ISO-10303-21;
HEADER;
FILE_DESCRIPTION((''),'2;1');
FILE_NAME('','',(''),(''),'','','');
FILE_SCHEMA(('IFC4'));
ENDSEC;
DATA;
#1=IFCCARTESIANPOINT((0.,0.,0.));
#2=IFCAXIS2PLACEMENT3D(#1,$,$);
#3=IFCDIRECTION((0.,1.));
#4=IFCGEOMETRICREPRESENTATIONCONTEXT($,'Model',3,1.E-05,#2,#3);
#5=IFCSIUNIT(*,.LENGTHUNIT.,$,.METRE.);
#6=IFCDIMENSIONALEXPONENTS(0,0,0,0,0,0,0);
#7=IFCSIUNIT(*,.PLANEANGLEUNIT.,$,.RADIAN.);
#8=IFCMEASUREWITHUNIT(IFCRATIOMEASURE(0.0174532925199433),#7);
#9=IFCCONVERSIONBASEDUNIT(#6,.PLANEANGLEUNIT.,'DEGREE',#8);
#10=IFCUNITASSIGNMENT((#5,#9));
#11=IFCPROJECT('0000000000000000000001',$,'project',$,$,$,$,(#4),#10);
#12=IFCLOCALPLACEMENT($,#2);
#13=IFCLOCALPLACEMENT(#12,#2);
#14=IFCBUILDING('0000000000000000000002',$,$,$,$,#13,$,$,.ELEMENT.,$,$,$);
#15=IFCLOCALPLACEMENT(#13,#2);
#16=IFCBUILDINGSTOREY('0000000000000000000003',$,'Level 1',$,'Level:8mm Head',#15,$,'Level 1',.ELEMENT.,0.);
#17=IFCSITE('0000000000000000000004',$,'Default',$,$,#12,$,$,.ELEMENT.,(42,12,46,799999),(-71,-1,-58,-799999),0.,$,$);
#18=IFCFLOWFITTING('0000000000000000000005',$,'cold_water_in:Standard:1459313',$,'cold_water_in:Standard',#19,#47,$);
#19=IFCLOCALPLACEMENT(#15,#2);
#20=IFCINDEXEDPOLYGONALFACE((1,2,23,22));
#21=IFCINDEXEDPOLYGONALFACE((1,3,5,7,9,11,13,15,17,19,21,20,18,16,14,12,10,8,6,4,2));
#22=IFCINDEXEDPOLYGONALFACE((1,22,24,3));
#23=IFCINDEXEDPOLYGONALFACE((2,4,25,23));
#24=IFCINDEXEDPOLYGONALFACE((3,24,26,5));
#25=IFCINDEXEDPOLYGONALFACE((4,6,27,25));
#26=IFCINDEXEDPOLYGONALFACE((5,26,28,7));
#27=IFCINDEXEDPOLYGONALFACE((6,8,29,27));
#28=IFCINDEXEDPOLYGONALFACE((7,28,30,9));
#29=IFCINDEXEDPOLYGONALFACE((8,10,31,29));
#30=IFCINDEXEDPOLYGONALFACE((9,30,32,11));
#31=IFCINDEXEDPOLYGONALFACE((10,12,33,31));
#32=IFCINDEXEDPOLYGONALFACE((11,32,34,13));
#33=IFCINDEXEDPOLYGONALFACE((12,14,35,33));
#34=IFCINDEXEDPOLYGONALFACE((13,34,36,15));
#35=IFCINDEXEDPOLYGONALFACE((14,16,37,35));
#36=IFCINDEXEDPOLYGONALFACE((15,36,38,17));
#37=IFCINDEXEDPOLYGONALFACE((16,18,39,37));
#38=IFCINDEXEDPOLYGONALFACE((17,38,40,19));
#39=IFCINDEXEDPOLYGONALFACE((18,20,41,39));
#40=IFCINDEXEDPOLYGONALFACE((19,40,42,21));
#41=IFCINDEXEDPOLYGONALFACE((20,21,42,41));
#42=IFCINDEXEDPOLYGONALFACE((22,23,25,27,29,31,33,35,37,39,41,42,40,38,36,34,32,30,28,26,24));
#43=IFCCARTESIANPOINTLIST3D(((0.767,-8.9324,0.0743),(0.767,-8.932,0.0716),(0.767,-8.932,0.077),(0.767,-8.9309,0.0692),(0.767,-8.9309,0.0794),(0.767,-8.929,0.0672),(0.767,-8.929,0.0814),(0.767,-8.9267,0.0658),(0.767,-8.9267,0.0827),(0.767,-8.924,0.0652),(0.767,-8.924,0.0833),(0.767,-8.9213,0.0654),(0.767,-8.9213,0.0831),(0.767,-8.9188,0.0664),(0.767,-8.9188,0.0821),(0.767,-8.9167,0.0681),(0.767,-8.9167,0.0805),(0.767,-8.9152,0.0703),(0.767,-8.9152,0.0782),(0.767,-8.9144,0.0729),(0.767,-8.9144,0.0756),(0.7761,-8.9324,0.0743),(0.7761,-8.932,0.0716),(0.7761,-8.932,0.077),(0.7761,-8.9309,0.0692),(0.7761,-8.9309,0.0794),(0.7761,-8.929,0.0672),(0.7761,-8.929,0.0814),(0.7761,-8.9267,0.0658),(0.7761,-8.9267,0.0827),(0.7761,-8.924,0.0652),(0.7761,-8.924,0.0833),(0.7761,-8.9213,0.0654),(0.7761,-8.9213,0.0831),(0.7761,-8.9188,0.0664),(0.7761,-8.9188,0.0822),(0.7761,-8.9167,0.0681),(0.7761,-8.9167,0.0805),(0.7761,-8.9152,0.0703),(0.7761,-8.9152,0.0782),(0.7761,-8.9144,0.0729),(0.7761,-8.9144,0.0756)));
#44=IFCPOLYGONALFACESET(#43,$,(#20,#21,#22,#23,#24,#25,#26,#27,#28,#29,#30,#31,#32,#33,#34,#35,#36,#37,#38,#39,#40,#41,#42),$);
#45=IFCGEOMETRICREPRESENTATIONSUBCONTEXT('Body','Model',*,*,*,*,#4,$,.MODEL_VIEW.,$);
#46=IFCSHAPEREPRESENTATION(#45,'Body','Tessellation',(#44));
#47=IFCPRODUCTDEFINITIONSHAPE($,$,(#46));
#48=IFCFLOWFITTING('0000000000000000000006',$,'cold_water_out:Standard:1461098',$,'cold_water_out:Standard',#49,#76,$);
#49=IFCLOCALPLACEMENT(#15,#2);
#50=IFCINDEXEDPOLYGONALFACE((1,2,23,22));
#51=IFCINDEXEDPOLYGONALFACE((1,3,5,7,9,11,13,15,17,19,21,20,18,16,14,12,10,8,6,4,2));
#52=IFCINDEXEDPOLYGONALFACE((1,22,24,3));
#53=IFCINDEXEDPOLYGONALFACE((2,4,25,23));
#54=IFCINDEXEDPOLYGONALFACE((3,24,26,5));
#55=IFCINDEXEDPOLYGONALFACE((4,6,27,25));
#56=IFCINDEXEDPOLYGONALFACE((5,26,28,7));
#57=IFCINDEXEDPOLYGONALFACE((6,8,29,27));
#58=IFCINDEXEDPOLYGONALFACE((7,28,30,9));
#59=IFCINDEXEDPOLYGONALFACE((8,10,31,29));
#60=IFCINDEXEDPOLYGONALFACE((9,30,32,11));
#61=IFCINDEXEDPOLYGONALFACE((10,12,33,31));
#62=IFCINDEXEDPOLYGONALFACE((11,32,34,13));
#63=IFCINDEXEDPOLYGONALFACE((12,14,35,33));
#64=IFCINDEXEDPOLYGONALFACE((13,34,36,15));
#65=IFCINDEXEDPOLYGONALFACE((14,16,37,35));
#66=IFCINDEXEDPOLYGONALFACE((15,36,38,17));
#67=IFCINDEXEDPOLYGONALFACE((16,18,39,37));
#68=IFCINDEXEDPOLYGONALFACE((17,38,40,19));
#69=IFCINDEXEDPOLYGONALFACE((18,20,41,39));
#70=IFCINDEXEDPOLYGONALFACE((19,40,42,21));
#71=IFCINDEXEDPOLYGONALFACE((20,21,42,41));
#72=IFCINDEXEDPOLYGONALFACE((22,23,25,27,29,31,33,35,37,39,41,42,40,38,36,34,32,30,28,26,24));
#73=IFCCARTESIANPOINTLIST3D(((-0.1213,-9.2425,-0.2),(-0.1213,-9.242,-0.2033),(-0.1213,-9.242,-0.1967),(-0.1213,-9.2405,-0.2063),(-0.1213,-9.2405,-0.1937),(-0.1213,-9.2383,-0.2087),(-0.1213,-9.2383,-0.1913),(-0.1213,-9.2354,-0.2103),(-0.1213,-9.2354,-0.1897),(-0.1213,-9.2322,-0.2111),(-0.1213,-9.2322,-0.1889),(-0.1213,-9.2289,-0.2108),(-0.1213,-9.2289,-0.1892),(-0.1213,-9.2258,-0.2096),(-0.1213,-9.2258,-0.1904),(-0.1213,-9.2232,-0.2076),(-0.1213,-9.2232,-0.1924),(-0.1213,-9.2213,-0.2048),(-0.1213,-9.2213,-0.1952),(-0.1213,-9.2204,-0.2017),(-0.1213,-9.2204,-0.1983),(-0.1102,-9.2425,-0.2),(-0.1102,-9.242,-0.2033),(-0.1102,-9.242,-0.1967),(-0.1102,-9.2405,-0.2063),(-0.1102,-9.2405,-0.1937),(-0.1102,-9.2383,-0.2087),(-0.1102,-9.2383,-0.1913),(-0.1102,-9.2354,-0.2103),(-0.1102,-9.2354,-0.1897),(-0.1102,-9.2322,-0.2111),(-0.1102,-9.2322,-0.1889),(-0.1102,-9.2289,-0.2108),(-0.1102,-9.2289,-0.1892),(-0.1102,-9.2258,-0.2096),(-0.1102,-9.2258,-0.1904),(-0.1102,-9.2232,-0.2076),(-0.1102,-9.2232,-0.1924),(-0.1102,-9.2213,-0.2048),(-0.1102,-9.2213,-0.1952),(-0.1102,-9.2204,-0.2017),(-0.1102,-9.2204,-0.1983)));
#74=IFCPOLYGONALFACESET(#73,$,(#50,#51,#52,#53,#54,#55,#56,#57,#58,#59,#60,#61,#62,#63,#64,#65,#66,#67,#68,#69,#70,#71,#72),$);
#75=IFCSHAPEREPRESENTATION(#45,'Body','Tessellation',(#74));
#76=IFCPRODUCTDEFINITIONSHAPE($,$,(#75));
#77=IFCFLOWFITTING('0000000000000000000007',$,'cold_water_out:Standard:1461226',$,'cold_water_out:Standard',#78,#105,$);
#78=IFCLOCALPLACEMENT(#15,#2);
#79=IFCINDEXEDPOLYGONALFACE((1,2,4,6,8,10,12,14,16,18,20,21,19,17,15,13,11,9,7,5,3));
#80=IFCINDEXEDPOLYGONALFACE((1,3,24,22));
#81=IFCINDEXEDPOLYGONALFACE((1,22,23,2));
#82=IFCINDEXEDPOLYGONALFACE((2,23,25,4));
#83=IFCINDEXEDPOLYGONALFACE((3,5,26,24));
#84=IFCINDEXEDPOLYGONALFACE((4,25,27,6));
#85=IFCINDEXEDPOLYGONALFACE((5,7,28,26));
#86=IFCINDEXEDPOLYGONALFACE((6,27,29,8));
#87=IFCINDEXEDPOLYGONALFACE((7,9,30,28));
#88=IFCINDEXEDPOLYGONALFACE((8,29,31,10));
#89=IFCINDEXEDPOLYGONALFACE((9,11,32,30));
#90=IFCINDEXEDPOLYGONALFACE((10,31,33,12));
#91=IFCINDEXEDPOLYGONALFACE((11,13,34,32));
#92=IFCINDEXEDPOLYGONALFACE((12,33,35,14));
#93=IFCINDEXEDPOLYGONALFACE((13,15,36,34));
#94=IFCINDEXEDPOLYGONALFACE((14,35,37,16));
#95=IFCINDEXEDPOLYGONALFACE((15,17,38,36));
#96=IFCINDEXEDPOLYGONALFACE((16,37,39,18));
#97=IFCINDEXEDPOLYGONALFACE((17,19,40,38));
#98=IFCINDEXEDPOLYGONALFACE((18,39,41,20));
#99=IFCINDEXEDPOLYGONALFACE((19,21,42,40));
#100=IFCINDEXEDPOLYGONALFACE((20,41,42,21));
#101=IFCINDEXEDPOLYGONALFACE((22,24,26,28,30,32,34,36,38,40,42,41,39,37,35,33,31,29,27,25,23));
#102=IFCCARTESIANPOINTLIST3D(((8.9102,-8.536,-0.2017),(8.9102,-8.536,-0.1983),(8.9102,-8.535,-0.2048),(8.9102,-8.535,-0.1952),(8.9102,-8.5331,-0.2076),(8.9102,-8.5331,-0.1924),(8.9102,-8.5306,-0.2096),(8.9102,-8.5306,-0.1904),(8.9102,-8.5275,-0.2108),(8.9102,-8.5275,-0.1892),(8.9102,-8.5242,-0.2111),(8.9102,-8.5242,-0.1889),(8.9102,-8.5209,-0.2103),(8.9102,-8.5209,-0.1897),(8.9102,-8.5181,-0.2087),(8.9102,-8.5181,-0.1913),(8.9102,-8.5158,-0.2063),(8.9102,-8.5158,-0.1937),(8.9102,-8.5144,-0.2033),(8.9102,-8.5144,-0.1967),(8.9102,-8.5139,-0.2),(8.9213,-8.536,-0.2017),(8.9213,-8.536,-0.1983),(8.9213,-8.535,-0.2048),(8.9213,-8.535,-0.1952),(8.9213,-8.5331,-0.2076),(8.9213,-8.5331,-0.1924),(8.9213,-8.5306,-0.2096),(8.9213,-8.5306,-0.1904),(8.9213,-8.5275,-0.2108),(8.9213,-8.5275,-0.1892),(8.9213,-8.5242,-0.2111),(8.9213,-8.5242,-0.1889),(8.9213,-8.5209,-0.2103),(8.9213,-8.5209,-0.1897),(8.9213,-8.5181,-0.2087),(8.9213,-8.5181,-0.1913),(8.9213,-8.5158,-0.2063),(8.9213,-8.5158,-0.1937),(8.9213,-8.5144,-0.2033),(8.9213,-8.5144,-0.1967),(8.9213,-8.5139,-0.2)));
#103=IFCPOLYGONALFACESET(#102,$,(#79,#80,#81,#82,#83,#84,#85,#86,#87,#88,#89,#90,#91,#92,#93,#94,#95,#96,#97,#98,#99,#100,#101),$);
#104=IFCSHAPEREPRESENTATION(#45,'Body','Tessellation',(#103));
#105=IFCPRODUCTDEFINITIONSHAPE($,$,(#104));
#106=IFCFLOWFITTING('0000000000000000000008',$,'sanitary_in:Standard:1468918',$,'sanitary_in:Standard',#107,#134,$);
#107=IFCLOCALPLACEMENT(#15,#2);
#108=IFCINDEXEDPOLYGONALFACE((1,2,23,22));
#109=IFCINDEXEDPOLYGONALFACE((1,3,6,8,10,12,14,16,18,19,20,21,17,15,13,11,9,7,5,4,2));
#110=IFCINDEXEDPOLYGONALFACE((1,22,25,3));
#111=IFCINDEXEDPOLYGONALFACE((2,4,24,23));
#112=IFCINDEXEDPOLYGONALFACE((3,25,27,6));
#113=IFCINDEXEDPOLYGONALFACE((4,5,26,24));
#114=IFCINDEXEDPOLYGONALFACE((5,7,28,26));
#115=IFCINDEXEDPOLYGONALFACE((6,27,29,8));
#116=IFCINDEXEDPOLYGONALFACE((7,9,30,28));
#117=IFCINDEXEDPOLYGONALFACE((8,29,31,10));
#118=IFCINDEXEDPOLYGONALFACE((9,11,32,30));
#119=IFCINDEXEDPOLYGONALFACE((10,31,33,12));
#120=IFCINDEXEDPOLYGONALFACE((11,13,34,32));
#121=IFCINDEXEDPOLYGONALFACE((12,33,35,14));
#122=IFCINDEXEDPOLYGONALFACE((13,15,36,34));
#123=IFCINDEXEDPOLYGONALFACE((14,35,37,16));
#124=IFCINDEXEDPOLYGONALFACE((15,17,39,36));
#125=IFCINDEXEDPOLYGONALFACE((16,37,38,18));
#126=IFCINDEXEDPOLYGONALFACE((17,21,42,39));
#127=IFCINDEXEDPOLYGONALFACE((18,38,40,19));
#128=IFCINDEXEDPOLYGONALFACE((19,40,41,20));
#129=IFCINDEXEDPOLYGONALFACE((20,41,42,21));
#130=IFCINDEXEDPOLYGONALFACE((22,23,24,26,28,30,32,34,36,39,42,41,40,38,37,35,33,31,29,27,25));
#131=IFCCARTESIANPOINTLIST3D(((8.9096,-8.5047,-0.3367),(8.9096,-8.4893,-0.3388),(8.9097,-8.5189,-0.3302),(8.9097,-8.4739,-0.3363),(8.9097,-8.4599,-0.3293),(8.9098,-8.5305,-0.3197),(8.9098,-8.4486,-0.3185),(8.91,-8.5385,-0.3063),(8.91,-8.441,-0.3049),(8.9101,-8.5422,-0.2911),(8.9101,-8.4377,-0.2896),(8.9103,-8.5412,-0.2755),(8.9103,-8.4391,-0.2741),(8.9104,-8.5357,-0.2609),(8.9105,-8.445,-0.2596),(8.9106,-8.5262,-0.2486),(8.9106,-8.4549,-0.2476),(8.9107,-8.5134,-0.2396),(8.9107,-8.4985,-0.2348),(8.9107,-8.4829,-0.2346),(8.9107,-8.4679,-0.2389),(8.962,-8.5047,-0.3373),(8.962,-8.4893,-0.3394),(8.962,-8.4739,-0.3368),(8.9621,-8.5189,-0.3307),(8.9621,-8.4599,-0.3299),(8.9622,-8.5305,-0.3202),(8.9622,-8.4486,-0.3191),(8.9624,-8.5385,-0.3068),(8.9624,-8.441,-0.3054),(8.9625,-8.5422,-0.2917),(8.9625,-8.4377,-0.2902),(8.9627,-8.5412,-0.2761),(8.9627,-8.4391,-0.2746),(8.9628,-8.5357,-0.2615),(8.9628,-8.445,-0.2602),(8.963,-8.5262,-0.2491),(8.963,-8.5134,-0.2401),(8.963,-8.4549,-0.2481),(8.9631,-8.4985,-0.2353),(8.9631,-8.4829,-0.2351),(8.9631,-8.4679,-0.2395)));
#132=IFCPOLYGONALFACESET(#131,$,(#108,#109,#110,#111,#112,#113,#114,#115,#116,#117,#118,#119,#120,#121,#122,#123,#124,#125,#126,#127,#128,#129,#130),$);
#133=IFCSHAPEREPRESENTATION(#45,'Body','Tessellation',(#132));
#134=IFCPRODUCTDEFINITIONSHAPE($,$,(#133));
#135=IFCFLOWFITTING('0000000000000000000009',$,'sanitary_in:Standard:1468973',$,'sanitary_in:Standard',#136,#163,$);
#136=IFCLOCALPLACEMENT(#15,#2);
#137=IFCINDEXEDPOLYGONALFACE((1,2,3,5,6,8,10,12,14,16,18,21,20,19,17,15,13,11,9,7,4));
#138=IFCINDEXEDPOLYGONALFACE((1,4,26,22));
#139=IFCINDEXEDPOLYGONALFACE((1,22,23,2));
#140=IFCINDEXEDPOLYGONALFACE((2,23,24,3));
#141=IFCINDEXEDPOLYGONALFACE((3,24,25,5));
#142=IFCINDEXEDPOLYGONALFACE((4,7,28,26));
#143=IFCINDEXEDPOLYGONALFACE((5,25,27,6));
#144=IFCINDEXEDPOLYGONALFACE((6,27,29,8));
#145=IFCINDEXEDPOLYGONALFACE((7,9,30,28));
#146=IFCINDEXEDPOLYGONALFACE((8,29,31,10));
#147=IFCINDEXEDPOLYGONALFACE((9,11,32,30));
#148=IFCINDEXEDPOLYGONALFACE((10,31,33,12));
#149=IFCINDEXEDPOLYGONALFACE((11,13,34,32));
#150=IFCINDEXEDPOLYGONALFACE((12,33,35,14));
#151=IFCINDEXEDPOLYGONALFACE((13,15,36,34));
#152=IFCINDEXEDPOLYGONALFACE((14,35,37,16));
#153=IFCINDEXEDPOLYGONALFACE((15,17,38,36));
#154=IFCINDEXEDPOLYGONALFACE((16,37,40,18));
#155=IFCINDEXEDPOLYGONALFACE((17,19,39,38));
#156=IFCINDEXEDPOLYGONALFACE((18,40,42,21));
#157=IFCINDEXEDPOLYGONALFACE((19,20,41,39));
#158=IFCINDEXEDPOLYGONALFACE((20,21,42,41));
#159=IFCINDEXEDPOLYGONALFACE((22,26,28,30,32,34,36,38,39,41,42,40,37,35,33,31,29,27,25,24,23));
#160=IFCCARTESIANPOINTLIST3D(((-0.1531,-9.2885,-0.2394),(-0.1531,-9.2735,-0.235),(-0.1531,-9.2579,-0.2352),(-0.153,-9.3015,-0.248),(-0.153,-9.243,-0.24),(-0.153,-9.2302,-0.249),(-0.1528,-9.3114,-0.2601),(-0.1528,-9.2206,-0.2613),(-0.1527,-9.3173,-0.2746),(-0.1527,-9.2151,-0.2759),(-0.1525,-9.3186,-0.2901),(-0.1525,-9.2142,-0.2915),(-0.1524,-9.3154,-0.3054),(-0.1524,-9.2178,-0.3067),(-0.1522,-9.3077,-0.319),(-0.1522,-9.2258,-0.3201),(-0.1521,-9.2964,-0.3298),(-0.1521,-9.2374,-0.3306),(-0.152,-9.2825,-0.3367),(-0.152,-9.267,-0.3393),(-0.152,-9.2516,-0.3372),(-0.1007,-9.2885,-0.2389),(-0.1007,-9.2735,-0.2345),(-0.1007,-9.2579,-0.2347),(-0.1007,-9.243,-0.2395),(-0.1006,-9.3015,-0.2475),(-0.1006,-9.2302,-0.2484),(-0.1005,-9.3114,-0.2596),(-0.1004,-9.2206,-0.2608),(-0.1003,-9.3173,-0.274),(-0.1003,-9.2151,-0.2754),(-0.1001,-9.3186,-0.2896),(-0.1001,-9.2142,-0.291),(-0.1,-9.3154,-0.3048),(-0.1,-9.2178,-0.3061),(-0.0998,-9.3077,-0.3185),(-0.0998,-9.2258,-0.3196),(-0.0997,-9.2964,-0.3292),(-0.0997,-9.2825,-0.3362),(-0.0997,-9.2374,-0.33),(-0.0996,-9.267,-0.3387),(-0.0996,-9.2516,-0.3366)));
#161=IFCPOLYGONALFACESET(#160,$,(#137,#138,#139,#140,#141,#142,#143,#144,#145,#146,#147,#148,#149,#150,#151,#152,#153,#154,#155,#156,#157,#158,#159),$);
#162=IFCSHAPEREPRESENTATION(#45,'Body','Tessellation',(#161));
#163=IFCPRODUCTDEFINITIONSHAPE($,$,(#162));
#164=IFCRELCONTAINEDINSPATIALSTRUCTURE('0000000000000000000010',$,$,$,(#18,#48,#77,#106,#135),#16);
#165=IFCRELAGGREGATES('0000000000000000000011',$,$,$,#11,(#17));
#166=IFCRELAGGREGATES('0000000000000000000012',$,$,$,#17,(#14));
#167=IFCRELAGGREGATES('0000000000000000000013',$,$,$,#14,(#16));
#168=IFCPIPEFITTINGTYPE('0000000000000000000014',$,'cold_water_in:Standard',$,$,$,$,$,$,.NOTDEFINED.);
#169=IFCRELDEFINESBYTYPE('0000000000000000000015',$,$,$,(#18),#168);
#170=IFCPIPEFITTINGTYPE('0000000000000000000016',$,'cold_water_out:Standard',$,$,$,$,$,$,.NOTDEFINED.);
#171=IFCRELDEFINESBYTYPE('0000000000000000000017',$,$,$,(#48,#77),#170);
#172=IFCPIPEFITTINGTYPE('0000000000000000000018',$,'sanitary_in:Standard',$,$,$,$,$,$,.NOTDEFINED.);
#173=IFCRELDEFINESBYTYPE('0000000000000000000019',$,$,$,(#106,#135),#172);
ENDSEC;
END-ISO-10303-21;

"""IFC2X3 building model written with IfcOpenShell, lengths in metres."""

from ifc_helpers import new_model, entity, si_unit, converted_unit, direction, frame, frame_2d, origin, place, context, subcontext, project, spatial, circle, extrude, source, transform, mapped, type_object, type_shapes, element, save


model = new_model("IFC2X3")

# Units and contexts
model_context = context("Model", 3, precision=1e-05, world=origin(), true_north=direction((0.0, 1.0)))
body_context = subcontext(model_context, "Body", "Model", "MODEL_VIEW")
ifc_project = project(units=[si_unit("LENGTHUNIT", "METRE"), converted_unit("PLANEANGLEUNIT", "DEGREE", entity("IfcRatioMeasure", 0.0174532925199433), si_unit("PLANEANGLEUNIT", "RADIAN"), dimensions=[0, 0, 0, 0, 0, 0, 0])], contexts=[model_context])

# Site, building, storey
site_placement = place(None, origin())
site = spatial("IfcSite", under=ifc_project, at=site_placement, Name="Default", CompositionType="ELEMENT", RefLatitude=(42, 12, 46, 799999), RefLongitude=(-71, -1, -58, -799999), RefElevation=0.0)
building_placement = place(site_placement, origin())
building = spatial("IfcBuilding", under=site, at=building_placement, CompositionType="ELEMENT")
storey_placement = place(building_placement, origin())
storey = spatial("IfcBuildingStorey", under=building, at=storey_placement, Name="Level 1", ObjectType="Level:8mm Head", LongName="Level 1", CompositionType="ELEMENT", Elevation=0.0)

# Flow fittings
pipe_fitting_type_1 = type_object("IfcPipeFittingType", Name="cold_water_in:Standard", PredefinedType="NOTDEFINED")
shared_shape_1 = source(origin(), body_context, "Body", "SweptSolid", [
    extrude(circle(Radius=0.0091, at=frame_2d((0.0, 0.0), x_axis=(1.0, 0.0))), frame((0.0, 0.0, 0.0), z_axis=(1.0, 0.0, 0.0), x_axis=(0.0, 1.0, 0.0)), (0.0, 0.0, 1.0), 0.0091),
])
type_shapes(pipe_fitting_type_1, [shared_shape_1])
flow_fitting_1_placement = place(storey_placement, frame((0.7761, -8.9234, 0.0743), z_axis=(-0.000149, 0.0, 1.0), x_axis=(-1.0, 0.0, -0.000149)))
element("IfcFlowFitting", 1, at=flow_fitting_1_placement, inside=storey, type_object=pipe_fitting_type_1, Name="cold_water_in:Standard:1459313", ObjectType="cold_water_in:Standard", context=body_context, shape_type="MappedRepresentation", body=[
    mapped(shared_shape_1, transform((0.0, 0.0, 0.0), scale=1.0)),
])
pipe_fitting_type_2 = type_object("IfcPipeFittingType", Name="cold_water_out:Standard", PredefinedType="NOTDEFINED")
shared_shape_2 = source(origin(), body_context, "Body", "SweptSolid", [
    extrude(circle(Radius=0.0111, at=frame_2d((0.0, 0.0), x_axis=(1.0, 0.0))), frame((0.0, 0.0, 0.0), z_axis=(1.0, 0.0, 0.0), x_axis=(0.0, 1.0, 0.0)), (0.0, 0.0, 1.0), 0.0111),
])
type_shapes(pipe_fitting_type_2, [shared_shape_2])
flow_fitting_2_placement = place(storey_placement, frame((-0.1102, -9.2314, -0.2), z_axis=(0.0, 0.0, 1.0), x_axis=(-1.0, 0.0, 0.0)))
element("IfcFlowFitting", 2, at=flow_fitting_2_placement, inside=storey, type_object=pipe_fitting_type_2, Name="cold_water_out:Standard:1461098", ObjectType="cold_water_out:Standard", context=body_context, shape_type="MappedRepresentation", body=[
    mapped(shared_shape_2, transform((0.0, 0.0, 0.0), scale=1.0)),
])
flow_fitting_3_placement = place(storey_placement, frame((8.9102, -8.525, -0.2)))
element("IfcFlowFitting", 3, at=flow_fitting_3_placement, inside=storey, type_object=pipe_fitting_type_2, Name="cold_water_out:Standard:1461226", ObjectType="cold_water_out:Standard", context=body_context, shape_type="MappedRepresentation", body=[
    mapped(shared_shape_2, transform((0.0, 0.0, 0.0), scale=1.0)),
])
pipe_fitting_type_3 = type_object("IfcPipeFittingType", Name="sanitary_in:Standard", PredefinedType="NOTDEFINED")
shared_shape_3 = source(origin(), body_context, "Body", "SweptSolid", [
    extrude(circle(Radius=0.0524, at=frame_2d((0.0, 0.0), x_axis=(1.0, 0.0))), frame((0.0, 0.0, 0.0), z_axis=(1.0, 0.0, 0.0), x_axis=(0.0, 1.0, 0.0)), (0.0, 0.0, 1.0), 0.0524),
])
type_shapes(pipe_fitting_type_3, [shared_shape_3])
for number, where, z_axis, x_axis, name in (
    (4, (8.9102, -8.49, -0.2865), (0.001406, -0.990844, 0.135005), (0.999946, 0.0, -0.010416), "sanitary_in:Standard:1468918"),
    (5, (-0.1002, -9.2664, -0.2864), (-0.001416, 0.990711, 0.135974), (-0.999946, 0.0, -0.010416), "sanitary_in:Standard:1468973"),
):
    element("IfcFlowFitting", number, at=place(storey_placement, frame(where, z_axis=z_axis, x_axis=x_axis)), inside=storey, type_object=pipe_fitting_type_3, Name=name, ObjectType="sanitary_in:Standard", context=body_context, shape_type="MappedRepresentation", body=[
        mapped(shared_shape_3, transform((0.0, 0.0, 0.0), scale=1.0)),
    ])

save(model, "model.ifc")
